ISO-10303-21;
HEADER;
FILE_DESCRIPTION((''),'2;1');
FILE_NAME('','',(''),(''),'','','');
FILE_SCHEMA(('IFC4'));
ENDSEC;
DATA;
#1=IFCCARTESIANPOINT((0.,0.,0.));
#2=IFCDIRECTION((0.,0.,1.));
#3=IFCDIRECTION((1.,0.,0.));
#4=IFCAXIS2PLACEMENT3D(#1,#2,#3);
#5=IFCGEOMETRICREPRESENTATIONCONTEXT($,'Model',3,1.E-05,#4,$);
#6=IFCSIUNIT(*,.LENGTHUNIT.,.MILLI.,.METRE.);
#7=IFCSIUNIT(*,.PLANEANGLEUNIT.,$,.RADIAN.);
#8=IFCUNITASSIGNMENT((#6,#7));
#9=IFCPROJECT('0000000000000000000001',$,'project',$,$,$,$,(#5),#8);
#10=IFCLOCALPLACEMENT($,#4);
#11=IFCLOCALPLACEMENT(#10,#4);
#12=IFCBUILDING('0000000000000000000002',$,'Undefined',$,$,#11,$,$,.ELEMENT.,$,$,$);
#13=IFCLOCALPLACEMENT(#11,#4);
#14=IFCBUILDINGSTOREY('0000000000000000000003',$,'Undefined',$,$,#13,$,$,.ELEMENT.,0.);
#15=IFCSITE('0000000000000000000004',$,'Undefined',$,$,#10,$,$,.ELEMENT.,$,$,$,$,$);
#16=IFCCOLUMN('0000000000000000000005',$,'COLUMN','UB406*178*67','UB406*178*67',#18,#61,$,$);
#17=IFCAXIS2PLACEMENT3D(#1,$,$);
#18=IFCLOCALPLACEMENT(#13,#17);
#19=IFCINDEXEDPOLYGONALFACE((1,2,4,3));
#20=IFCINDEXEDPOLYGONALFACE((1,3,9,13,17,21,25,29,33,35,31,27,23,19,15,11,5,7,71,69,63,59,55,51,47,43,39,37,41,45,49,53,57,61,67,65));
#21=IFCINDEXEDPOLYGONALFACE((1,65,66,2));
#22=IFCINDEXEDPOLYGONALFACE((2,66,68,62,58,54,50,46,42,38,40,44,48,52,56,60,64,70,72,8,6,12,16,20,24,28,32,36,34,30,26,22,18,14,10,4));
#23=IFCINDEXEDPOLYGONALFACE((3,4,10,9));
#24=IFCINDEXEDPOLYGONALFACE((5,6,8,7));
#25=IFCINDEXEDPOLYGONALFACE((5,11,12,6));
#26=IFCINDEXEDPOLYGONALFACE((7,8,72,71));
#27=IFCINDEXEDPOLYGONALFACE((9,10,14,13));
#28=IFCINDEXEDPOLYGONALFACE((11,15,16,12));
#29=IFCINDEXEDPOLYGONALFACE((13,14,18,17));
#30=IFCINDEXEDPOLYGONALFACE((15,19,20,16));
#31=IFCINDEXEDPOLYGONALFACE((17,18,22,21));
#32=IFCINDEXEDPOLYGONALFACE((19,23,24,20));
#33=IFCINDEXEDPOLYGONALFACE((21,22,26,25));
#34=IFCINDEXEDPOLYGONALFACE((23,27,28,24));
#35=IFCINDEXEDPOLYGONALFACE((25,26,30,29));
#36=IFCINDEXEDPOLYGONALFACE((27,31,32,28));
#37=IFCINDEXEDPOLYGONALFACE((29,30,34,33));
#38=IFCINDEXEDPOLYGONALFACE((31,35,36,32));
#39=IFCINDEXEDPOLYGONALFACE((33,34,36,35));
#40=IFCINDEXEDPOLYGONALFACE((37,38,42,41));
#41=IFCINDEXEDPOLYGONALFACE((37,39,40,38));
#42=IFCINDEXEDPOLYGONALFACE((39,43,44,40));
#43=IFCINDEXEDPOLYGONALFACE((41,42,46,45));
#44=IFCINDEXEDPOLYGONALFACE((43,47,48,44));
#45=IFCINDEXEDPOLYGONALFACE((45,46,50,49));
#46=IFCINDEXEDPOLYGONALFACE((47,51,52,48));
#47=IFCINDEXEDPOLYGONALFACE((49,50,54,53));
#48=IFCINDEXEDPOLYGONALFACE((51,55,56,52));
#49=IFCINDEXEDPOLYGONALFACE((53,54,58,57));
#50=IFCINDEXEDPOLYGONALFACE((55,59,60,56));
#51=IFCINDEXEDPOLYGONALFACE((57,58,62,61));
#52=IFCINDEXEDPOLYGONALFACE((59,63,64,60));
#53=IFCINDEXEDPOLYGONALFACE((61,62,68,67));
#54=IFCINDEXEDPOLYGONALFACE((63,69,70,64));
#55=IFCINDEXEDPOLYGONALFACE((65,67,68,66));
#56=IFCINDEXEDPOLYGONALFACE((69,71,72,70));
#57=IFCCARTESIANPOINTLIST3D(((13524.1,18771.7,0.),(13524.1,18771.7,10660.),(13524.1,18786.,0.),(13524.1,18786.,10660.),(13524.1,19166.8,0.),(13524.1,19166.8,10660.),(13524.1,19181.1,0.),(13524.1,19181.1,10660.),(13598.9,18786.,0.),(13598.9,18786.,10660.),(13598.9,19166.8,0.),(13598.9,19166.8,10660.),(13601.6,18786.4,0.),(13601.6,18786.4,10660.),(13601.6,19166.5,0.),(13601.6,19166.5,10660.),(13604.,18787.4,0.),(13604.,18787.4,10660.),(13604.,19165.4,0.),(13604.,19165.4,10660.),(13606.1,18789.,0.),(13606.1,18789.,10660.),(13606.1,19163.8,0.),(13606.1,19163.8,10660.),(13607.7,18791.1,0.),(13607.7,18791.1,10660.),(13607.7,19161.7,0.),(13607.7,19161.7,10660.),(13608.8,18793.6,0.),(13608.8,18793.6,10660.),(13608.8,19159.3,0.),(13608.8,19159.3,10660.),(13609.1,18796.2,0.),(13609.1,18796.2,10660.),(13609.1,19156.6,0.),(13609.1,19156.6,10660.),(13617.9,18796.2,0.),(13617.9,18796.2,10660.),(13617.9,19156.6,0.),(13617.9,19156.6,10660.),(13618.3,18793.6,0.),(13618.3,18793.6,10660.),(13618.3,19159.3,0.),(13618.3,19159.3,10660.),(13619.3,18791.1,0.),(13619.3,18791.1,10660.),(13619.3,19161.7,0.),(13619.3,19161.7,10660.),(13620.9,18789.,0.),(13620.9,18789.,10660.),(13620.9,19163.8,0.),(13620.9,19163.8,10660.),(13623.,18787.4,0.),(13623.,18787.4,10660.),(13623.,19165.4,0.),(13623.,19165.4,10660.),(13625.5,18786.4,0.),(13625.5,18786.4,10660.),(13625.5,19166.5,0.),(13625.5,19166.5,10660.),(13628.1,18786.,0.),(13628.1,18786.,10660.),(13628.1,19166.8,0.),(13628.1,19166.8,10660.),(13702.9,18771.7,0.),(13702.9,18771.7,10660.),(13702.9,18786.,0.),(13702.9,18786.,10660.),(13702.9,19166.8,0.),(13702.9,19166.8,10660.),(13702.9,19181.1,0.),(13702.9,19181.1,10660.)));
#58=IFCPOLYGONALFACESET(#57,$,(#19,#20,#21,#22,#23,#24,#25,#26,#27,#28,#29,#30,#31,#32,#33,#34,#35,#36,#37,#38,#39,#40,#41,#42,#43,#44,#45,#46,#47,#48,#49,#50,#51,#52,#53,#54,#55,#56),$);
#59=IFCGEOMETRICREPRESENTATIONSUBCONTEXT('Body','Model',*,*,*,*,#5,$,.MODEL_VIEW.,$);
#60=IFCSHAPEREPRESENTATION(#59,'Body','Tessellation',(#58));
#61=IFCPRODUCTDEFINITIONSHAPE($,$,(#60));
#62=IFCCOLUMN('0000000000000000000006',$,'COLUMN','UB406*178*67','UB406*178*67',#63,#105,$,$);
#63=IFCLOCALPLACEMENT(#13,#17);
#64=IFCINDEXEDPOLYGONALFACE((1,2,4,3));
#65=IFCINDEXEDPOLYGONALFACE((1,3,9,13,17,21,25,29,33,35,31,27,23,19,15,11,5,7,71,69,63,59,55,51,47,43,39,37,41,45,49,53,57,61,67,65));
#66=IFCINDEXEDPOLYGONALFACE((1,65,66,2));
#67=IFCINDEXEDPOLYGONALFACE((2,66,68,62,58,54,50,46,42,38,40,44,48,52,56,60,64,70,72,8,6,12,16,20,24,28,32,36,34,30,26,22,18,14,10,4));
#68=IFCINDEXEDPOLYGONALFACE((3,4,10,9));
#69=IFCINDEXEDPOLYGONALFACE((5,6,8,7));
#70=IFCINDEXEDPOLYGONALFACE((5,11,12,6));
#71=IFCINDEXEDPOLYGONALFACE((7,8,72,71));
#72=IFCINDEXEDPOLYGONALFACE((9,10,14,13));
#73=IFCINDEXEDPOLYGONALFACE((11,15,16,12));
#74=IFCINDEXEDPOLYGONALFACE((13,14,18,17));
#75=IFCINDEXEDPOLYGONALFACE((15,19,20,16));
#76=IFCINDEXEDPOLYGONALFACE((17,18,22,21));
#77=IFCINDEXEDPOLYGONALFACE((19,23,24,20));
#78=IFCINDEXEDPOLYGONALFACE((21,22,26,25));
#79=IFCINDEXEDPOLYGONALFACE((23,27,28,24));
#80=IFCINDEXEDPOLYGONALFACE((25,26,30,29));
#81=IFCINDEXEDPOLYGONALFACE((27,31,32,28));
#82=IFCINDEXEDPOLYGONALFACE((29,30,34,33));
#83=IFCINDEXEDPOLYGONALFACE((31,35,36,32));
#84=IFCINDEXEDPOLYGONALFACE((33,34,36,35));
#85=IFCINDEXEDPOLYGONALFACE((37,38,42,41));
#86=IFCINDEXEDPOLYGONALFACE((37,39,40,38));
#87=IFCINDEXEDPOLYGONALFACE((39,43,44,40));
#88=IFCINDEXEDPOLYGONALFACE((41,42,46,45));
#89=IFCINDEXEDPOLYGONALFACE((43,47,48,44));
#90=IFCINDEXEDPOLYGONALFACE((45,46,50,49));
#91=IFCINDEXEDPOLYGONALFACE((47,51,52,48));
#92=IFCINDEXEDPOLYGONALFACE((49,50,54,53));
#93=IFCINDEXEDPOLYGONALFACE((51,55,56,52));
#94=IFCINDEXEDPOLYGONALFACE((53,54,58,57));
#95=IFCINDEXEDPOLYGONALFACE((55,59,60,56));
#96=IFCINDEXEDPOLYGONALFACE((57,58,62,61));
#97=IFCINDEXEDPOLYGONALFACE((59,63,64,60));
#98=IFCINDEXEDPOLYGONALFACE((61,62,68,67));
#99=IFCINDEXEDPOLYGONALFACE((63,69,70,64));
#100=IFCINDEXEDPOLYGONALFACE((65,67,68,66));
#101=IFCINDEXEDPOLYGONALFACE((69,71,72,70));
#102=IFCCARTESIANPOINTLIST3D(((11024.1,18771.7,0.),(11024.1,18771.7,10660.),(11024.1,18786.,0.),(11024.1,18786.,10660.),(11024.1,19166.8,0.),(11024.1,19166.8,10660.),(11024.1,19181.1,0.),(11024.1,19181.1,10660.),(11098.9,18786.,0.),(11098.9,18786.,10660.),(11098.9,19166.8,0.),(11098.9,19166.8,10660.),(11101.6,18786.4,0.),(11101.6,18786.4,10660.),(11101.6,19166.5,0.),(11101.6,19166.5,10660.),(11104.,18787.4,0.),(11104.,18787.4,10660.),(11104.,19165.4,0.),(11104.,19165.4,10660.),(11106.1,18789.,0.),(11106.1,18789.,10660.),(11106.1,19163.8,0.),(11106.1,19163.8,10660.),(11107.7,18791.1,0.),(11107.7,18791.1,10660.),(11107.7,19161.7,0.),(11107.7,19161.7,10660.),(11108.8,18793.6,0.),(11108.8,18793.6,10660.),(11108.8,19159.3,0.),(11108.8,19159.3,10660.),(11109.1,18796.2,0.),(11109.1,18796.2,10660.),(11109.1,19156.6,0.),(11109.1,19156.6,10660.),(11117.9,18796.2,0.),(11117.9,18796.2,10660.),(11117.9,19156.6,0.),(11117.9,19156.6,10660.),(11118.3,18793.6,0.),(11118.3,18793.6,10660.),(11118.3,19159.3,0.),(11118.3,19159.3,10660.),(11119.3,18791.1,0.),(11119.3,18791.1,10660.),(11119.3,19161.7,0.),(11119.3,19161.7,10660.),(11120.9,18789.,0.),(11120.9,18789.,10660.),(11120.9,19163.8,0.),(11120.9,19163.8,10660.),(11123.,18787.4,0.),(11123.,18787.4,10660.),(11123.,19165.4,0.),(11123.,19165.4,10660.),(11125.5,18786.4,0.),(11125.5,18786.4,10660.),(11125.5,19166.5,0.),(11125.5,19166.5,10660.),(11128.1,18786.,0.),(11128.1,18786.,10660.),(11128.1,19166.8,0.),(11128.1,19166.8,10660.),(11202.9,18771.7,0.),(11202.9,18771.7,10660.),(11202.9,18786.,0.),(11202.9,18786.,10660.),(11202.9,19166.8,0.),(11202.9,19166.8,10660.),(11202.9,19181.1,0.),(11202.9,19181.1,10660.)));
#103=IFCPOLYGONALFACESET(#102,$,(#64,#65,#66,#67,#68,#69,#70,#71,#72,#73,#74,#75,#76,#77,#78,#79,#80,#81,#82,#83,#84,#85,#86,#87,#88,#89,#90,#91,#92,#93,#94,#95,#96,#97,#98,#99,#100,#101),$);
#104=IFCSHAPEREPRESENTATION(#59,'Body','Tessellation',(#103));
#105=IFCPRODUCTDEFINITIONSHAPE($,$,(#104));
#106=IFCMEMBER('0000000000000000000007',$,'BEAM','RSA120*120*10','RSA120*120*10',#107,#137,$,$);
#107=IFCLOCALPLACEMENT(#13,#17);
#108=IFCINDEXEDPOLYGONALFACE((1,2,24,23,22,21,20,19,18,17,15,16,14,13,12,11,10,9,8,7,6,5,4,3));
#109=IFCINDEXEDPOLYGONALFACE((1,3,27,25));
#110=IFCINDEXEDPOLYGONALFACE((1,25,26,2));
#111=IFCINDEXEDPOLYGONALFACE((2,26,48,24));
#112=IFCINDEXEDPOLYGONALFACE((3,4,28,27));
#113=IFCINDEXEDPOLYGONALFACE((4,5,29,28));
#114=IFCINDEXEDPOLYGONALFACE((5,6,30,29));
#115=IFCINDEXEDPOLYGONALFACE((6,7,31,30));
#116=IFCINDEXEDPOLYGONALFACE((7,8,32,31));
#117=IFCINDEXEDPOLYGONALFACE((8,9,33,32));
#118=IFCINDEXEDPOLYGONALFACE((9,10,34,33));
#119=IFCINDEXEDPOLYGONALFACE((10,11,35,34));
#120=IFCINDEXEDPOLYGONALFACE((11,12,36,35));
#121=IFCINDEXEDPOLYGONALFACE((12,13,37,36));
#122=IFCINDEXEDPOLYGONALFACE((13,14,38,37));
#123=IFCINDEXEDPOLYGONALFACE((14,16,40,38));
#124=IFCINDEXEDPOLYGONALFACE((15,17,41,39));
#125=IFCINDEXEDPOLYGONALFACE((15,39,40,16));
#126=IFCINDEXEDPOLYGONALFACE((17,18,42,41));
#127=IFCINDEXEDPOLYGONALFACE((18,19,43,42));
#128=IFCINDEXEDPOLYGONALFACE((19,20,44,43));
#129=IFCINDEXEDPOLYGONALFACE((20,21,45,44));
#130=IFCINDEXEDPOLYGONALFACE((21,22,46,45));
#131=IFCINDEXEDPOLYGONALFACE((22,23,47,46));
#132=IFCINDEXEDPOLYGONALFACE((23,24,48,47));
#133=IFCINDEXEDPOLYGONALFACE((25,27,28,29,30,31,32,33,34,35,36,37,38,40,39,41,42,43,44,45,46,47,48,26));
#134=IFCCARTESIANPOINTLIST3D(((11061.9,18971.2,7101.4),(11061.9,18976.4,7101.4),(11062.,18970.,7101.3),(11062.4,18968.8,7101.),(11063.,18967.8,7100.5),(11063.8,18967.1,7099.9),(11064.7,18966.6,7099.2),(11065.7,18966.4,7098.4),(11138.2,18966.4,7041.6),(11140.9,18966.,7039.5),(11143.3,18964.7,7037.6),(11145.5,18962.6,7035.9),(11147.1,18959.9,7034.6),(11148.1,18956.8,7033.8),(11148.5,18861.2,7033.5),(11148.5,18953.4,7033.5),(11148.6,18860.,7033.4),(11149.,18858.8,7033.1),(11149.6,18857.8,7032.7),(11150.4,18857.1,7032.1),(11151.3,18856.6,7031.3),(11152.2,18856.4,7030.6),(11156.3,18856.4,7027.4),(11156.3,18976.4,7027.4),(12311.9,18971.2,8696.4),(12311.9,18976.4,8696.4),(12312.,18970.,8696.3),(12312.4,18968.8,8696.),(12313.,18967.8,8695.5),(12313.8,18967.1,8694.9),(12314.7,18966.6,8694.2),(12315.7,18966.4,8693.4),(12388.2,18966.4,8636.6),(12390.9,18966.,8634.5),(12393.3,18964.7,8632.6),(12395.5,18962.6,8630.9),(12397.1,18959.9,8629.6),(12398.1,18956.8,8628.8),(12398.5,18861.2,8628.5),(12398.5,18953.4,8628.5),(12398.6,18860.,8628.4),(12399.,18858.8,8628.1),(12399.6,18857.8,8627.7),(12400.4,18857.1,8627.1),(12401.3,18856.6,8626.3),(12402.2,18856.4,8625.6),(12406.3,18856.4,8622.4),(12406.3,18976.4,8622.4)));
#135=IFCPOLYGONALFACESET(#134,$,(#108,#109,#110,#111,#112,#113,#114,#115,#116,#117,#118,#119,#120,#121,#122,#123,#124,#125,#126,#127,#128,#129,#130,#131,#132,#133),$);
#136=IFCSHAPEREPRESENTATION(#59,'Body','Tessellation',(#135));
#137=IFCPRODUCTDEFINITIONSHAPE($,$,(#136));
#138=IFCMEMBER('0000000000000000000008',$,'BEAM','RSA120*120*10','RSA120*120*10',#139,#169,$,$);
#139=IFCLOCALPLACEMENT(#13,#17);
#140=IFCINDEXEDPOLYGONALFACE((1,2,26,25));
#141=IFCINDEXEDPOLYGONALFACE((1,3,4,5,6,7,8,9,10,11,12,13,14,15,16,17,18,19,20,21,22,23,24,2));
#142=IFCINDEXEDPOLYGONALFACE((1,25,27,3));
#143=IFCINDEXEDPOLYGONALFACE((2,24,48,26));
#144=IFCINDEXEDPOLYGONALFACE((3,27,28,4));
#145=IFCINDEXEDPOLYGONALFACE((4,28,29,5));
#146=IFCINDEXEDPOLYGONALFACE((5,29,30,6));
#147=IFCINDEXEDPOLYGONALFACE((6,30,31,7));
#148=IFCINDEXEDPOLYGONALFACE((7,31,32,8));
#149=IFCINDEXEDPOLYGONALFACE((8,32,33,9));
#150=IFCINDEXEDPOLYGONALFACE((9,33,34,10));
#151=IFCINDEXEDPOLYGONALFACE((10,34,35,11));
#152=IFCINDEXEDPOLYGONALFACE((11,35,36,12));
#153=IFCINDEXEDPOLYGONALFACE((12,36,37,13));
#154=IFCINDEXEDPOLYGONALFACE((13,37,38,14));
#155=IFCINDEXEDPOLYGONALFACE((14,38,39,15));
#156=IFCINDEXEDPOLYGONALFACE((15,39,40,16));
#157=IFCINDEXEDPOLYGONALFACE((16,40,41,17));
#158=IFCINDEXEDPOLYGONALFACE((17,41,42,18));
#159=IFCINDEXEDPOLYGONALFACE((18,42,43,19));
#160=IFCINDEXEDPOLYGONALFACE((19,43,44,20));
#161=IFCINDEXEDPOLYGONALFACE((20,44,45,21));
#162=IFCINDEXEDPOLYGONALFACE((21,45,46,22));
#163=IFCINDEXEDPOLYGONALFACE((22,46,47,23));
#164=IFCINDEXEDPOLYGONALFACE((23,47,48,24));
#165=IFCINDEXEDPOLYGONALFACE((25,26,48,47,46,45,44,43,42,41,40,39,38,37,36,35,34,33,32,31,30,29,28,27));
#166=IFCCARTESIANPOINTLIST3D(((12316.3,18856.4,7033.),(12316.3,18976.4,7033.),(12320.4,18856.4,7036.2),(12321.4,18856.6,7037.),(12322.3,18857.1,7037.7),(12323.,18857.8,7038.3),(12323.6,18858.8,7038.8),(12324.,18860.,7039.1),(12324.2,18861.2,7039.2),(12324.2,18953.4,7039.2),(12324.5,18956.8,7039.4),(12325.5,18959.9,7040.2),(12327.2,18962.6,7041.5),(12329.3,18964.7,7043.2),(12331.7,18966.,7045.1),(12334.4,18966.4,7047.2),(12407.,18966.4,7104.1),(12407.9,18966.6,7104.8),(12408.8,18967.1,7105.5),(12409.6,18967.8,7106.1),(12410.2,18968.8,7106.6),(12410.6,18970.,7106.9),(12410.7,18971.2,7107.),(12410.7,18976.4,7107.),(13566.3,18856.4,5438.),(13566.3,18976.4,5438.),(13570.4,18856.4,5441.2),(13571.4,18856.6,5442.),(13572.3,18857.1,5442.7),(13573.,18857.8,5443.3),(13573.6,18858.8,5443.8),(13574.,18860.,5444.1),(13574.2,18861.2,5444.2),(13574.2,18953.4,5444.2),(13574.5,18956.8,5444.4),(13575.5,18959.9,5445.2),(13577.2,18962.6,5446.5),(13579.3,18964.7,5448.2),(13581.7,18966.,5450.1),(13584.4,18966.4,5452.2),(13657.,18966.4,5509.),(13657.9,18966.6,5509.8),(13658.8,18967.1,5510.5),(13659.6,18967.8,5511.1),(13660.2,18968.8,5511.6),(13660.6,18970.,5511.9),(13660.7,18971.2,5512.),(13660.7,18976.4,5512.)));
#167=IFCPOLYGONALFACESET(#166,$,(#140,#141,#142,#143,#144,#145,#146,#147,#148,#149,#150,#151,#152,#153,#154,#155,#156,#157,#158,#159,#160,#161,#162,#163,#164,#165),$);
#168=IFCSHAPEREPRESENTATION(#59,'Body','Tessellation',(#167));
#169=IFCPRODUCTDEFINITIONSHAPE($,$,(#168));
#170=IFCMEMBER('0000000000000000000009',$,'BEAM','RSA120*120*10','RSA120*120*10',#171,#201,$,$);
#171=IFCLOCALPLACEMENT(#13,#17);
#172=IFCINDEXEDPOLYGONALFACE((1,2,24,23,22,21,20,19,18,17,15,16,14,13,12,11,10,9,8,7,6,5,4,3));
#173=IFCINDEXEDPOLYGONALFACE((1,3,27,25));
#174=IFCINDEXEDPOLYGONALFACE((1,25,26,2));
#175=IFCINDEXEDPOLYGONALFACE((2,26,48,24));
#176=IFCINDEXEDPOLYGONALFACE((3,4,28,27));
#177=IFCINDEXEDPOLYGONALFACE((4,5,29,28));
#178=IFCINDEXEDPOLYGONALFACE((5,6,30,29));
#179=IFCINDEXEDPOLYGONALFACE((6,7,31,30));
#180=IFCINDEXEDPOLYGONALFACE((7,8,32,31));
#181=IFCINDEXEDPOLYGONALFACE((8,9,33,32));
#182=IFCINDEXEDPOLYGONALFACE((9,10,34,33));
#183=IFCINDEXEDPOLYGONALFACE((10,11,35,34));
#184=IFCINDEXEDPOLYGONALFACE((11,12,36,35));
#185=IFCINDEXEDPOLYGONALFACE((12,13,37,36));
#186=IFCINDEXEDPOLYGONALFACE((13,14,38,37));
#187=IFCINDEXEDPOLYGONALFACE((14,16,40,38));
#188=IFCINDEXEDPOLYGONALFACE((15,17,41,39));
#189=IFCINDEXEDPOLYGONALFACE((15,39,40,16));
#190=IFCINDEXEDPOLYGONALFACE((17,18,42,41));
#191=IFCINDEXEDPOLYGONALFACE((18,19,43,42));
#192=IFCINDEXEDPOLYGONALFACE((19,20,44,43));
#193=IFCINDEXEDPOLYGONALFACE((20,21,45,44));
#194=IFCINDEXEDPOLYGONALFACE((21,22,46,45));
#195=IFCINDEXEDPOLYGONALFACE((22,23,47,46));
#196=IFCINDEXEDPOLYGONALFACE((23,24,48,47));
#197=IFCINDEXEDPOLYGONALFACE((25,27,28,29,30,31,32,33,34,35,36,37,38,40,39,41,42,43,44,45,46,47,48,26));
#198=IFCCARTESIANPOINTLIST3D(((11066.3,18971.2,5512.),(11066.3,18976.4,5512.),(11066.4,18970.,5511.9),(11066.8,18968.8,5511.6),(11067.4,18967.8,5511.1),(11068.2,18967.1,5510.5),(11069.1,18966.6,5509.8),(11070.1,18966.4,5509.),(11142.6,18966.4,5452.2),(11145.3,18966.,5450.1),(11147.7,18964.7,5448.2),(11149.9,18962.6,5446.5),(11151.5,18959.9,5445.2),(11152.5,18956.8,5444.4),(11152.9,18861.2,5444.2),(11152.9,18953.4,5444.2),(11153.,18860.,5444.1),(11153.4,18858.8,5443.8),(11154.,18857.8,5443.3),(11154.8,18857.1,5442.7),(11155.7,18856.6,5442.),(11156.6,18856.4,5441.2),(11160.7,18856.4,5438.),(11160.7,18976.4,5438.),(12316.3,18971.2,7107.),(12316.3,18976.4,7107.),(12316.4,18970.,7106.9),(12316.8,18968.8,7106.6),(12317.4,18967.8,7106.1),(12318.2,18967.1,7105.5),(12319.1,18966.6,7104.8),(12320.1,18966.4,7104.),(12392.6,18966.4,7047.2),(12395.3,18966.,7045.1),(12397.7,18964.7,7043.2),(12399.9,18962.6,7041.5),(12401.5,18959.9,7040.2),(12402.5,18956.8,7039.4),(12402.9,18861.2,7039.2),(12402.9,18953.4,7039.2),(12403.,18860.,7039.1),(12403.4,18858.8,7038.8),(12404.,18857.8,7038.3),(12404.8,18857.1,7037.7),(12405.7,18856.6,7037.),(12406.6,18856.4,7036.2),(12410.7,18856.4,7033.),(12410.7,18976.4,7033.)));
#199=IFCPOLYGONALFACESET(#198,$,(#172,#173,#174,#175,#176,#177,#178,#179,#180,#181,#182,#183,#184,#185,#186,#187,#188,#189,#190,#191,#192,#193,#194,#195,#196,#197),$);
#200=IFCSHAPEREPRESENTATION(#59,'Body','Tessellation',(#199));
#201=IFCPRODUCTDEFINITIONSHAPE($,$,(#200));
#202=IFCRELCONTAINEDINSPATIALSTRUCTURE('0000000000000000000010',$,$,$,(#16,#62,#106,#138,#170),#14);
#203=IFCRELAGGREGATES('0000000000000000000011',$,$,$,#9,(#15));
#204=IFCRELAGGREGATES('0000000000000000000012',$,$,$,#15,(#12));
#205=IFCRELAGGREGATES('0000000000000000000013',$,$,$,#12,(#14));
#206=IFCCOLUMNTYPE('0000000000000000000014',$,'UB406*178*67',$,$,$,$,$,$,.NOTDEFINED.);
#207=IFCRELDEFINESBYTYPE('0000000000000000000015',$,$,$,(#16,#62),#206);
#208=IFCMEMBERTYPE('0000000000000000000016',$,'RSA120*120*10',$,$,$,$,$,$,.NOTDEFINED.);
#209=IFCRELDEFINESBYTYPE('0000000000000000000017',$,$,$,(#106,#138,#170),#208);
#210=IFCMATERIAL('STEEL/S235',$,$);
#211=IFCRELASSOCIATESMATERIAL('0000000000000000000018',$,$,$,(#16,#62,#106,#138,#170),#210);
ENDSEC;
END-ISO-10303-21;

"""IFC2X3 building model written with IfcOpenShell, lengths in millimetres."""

from ifc_helpers import new_model, si_unit, frame, origin_with_axes, origin_2d_with_axis, place, context, subcontext, project, spatial, i_section, l_section, extrude, material, type_object, element, save


model = new_model("IFC2X3")

# Units and contexts
model_context = context("Model", 3, precision=1e-05, world=origin_with_axes())
body_context = subcontext(model_context, "Body", "Model", "MODEL_VIEW")
ifc_project = project(units=[si_unit("LENGTHUNIT", "METRE", prefix="MILLI"), si_unit("PLANEANGLEUNIT", "RADIAN")], contexts=[model_context])

# Site, building, storey
site_placement = place(None, origin_with_axes())
site = spatial("IfcSite", under=ifc_project, at=site_placement, Name="Undefined", CompositionType="ELEMENT")
building_placement = place(site_placement, origin_with_axes())
building = spatial("IfcBuilding", under=site, at=building_placement, Name="Undefined", CompositionType="ELEMENT")
storey_placement = place(building_placement, origin_with_axes())
storey = spatial("IfcBuildingStorey", under=building, at=storey_placement, Name="Undefined", CompositionType="ELEMENT", Elevation=0.0)

# Columns
ifc_material = material(Name="STEEL/S235")
column_type = type_object("IfcColumnType", Name="UB406*178*67", PredefinedType="NOTDEFINED")
for number, where, z_axis, x_axis, name in (
    (1, (13613.5, 18976.4, 0.0), (0.0, 0.0, 1.0), (0.0, -1.0, 0.0), "COLUMN"),
    (2, (11113.5, 18976.4, 0.0), (0.0, 0.0, 1.0), (0.0, -1.0, 0.0), "COLUMN"),
):
    element("IfcColumn", number, at=place(storey_placement, frame(where, z_axis=z_axis, x_axis=x_axis)), inside=storey, type_object=column_type, material=ifc_material, Name=name, Description="UB406*178*67", ObjectType="UB406*178*67", context=body_context, shape_type="SweptSolid", body=[
        extrude(i_section(OverallWidth=178.8, OverallDepth=409.4, WebThickness=8.8, FlangeThickness=14.3, FilletRadius=10.2, at=origin_2d_with_axis()), frame((0.0, 0.0, 10660.0), z_axis=(0.0, 0.0, -1.0), x_axis=(0.0, 1.0, 0.0)), (0.0, 0.0, 1.0), 10660.0),
    ])

# Members
member_type_1 = type_object("IfcMemberType", Name="RSA120*120*10", PredefinedType="NOTDEFINED")
member_1_placement = place(storey_placement, frame((11109.1, 18916.4, 7064.4), z_axis=(-0.787088, 0.0, 0.616841), x_axis=(0.616841, 0.0, 0.787088)))
element("IfcMember", 3, at=member_1_placement, inside=storey, type_object=member_type_1, material=ifc_material, Name="BEAM", Description="RSA120*120*10", ObjectType="RSA120*120*10", context=body_context, shape_type="SweptSolid", body=[
    extrude(l_section(Depth=120.0, Width=120.0, Thickness=10.0, FilletRadius=13.0, EdgeRadius=4.8, at=origin_2d_with_axis()), frame((2026.5, 0.0, 0.0), z_axis=(-1.0, 0.0, 0.0), x_axis=(0.0, -1.0, 0.0)), (0.0, 0.0, 1.0), 2026.5),
])
member_2_placement = place(storey_placement, frame((12363.5, 18916.4, 7070.0), z_axis=(0.787088, 0.0, 0.61684), x_axis=(0.61684, 0.0, -0.787088)))
element("IfcMember", 4, at=member_2_placement, inside=storey, type_object=member_type_1, material=ifc_material, Name="BEAM", Description="RSA120*120*10", ObjectType="RSA120*120*10", context=body_context, shape_type="SweptSolid", body=[
    extrude(l_section(Depth=120.0, Width=120.0, Thickness=10.0, FilletRadius=13.0, EdgeRadius=4.8, at=origin_2d_with_axis()), frame((2026.5, 0.0, 0.0), z_axis=(-1.0, 0.0, 0.0), x_axis=(0.0, -1.0, 0.0)), (0.0, 0.0, 1.0), 2026.5),
])
member_3_placement = place(storey_placement, frame((11113.5, 18916.4, 5475.0), z_axis=(-0.787088, 0.0, 0.616841), x_axis=(0.616841, 0.0, 0.787088)))
element("IfcMember", 5, at=member_3_placement, inside=storey, type_object=member_type_1, material=ifc_material, Name="BEAM", Description="RSA120*120*10", ObjectType="RSA120*120*10", context=body_context, shape_type="SweptSolid", body=[
    extrude(l_section(Depth=120.0, Width=120.0, Thickness=10.0, FilletRadius=13.0, EdgeRadius=4.8, at=origin_2d_with_axis()), frame((2026.5, 0.0, 0.0), z_axis=(-1.0, 0.0, 0.0), x_axis=(0.0, -1.0, 0.0)), (0.0, 0.0, 1.0), 2026.5),
])

save(model, "model.ifc")
